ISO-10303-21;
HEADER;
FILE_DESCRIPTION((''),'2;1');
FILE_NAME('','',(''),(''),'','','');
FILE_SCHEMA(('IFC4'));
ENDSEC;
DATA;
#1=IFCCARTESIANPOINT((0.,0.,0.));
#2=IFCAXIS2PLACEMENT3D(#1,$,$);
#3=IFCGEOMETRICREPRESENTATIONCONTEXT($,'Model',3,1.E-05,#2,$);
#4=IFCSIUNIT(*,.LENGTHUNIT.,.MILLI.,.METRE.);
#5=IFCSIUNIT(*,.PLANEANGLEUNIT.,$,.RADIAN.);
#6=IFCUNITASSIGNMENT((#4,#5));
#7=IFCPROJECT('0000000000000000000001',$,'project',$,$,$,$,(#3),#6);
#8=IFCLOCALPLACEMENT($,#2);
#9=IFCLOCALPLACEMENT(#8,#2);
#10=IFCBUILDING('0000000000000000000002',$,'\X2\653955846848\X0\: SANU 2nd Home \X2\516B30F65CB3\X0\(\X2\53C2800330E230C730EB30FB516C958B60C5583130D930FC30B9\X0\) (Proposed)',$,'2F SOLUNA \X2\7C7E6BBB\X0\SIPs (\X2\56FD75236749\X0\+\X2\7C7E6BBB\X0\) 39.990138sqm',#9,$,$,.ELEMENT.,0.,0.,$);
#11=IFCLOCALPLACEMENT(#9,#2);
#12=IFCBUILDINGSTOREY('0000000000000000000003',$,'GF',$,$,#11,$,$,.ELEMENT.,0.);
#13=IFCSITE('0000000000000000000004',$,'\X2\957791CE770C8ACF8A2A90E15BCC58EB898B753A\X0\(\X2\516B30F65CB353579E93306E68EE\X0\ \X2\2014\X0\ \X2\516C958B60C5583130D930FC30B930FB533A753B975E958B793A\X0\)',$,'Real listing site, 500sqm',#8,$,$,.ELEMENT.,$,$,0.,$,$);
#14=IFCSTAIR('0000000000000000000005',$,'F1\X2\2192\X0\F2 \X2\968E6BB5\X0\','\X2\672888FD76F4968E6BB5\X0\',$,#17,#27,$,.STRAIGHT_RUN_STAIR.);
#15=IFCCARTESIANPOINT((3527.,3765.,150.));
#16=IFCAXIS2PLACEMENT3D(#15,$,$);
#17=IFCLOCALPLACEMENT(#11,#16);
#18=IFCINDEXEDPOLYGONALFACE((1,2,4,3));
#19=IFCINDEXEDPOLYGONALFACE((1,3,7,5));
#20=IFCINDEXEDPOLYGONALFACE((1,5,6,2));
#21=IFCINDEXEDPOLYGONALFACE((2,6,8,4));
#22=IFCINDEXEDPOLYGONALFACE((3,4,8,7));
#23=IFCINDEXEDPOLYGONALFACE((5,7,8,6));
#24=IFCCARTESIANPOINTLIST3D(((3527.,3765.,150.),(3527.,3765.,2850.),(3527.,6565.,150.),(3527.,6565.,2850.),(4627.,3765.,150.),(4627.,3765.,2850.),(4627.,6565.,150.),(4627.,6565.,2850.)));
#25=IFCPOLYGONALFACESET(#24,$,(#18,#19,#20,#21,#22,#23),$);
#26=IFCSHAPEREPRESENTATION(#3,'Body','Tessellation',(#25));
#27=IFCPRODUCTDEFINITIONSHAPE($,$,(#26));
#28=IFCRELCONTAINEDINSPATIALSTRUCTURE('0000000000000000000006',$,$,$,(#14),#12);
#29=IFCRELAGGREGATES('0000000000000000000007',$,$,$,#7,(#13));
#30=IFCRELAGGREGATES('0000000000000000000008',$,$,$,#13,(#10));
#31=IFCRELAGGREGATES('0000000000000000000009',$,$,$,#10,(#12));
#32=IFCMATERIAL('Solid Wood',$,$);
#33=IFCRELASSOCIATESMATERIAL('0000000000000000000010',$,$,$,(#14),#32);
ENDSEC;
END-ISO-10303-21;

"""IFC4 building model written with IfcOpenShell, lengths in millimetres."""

from ifc_helpers import new_model, si_unit, frame, frame_2d, origin, place, context, project, spatial, rectangle, extrude, material, element, save


model = new_model("IFC4")

# Units and contexts
model_context = context("Model", 3, precision=1e-05, world=origin())
ifc_project = project(units=[si_unit("LENGTHUNIT", "METRE", prefix="MILLI"), si_unit("PLANEANGLEUNIT", "RADIAN")], contexts=[model_context])

# Site, building, storey
site_placement = place(None, origin())
site = spatial("IfcSite", under=ifc_project, at=site_placement, Name="長野県諏訪郡富士見町(八ヶ岳南麓の森 — 公開情報ベース・区画非開示)", ObjectType="Real listing site, 500sqm", CompositionType="ELEMENT", RefElevation=0.0)
building_placement = place(site_placement, origin())
building = spatial("IfcBuilding", under=site, at=building_placement, Name="改善案: SANU 2nd Home 八ヶ岳(参考モデル・公開情報ベース) (Proposed)", ObjectType="2F SOLUNA 籾殻SIPs (国産杉+籾殻) 39.990138sqm", CompositionType="ELEMENT", ElevationOfRefHeight=0.0, ElevationOfTerrain=0.0)
storey_placement = place(building_placement, origin())
storey = spatial("IfcBuildingStorey", under=building, at=storey_placement, Name="GF", CompositionType="ELEMENT", Elevation=0.0)

# Stair
ifc_material_1 = material(Name="Solid Wood")
stair_placement = place(storey_placement, frame((3527.0, 3765.0, 150.0)))
element("IfcStair", 1, at=stair_placement, inside=storey, material=ifc_material_1, Name="F1→F2 階段", Description="木製直階段", PredefinedType="STRAIGHT_RUN_STAIR", context=model_context, shape_type="SweptSolid", body=[
    extrude(rectangle(XDim=1100.0, YDim=2800.0, at=frame_2d((550.0, 1400.0))), frame((3527.0, 3765.0, 150.0)), (0.0, 0.0, 1.0), 2700.0),
])

save(model, "model.ifc")
